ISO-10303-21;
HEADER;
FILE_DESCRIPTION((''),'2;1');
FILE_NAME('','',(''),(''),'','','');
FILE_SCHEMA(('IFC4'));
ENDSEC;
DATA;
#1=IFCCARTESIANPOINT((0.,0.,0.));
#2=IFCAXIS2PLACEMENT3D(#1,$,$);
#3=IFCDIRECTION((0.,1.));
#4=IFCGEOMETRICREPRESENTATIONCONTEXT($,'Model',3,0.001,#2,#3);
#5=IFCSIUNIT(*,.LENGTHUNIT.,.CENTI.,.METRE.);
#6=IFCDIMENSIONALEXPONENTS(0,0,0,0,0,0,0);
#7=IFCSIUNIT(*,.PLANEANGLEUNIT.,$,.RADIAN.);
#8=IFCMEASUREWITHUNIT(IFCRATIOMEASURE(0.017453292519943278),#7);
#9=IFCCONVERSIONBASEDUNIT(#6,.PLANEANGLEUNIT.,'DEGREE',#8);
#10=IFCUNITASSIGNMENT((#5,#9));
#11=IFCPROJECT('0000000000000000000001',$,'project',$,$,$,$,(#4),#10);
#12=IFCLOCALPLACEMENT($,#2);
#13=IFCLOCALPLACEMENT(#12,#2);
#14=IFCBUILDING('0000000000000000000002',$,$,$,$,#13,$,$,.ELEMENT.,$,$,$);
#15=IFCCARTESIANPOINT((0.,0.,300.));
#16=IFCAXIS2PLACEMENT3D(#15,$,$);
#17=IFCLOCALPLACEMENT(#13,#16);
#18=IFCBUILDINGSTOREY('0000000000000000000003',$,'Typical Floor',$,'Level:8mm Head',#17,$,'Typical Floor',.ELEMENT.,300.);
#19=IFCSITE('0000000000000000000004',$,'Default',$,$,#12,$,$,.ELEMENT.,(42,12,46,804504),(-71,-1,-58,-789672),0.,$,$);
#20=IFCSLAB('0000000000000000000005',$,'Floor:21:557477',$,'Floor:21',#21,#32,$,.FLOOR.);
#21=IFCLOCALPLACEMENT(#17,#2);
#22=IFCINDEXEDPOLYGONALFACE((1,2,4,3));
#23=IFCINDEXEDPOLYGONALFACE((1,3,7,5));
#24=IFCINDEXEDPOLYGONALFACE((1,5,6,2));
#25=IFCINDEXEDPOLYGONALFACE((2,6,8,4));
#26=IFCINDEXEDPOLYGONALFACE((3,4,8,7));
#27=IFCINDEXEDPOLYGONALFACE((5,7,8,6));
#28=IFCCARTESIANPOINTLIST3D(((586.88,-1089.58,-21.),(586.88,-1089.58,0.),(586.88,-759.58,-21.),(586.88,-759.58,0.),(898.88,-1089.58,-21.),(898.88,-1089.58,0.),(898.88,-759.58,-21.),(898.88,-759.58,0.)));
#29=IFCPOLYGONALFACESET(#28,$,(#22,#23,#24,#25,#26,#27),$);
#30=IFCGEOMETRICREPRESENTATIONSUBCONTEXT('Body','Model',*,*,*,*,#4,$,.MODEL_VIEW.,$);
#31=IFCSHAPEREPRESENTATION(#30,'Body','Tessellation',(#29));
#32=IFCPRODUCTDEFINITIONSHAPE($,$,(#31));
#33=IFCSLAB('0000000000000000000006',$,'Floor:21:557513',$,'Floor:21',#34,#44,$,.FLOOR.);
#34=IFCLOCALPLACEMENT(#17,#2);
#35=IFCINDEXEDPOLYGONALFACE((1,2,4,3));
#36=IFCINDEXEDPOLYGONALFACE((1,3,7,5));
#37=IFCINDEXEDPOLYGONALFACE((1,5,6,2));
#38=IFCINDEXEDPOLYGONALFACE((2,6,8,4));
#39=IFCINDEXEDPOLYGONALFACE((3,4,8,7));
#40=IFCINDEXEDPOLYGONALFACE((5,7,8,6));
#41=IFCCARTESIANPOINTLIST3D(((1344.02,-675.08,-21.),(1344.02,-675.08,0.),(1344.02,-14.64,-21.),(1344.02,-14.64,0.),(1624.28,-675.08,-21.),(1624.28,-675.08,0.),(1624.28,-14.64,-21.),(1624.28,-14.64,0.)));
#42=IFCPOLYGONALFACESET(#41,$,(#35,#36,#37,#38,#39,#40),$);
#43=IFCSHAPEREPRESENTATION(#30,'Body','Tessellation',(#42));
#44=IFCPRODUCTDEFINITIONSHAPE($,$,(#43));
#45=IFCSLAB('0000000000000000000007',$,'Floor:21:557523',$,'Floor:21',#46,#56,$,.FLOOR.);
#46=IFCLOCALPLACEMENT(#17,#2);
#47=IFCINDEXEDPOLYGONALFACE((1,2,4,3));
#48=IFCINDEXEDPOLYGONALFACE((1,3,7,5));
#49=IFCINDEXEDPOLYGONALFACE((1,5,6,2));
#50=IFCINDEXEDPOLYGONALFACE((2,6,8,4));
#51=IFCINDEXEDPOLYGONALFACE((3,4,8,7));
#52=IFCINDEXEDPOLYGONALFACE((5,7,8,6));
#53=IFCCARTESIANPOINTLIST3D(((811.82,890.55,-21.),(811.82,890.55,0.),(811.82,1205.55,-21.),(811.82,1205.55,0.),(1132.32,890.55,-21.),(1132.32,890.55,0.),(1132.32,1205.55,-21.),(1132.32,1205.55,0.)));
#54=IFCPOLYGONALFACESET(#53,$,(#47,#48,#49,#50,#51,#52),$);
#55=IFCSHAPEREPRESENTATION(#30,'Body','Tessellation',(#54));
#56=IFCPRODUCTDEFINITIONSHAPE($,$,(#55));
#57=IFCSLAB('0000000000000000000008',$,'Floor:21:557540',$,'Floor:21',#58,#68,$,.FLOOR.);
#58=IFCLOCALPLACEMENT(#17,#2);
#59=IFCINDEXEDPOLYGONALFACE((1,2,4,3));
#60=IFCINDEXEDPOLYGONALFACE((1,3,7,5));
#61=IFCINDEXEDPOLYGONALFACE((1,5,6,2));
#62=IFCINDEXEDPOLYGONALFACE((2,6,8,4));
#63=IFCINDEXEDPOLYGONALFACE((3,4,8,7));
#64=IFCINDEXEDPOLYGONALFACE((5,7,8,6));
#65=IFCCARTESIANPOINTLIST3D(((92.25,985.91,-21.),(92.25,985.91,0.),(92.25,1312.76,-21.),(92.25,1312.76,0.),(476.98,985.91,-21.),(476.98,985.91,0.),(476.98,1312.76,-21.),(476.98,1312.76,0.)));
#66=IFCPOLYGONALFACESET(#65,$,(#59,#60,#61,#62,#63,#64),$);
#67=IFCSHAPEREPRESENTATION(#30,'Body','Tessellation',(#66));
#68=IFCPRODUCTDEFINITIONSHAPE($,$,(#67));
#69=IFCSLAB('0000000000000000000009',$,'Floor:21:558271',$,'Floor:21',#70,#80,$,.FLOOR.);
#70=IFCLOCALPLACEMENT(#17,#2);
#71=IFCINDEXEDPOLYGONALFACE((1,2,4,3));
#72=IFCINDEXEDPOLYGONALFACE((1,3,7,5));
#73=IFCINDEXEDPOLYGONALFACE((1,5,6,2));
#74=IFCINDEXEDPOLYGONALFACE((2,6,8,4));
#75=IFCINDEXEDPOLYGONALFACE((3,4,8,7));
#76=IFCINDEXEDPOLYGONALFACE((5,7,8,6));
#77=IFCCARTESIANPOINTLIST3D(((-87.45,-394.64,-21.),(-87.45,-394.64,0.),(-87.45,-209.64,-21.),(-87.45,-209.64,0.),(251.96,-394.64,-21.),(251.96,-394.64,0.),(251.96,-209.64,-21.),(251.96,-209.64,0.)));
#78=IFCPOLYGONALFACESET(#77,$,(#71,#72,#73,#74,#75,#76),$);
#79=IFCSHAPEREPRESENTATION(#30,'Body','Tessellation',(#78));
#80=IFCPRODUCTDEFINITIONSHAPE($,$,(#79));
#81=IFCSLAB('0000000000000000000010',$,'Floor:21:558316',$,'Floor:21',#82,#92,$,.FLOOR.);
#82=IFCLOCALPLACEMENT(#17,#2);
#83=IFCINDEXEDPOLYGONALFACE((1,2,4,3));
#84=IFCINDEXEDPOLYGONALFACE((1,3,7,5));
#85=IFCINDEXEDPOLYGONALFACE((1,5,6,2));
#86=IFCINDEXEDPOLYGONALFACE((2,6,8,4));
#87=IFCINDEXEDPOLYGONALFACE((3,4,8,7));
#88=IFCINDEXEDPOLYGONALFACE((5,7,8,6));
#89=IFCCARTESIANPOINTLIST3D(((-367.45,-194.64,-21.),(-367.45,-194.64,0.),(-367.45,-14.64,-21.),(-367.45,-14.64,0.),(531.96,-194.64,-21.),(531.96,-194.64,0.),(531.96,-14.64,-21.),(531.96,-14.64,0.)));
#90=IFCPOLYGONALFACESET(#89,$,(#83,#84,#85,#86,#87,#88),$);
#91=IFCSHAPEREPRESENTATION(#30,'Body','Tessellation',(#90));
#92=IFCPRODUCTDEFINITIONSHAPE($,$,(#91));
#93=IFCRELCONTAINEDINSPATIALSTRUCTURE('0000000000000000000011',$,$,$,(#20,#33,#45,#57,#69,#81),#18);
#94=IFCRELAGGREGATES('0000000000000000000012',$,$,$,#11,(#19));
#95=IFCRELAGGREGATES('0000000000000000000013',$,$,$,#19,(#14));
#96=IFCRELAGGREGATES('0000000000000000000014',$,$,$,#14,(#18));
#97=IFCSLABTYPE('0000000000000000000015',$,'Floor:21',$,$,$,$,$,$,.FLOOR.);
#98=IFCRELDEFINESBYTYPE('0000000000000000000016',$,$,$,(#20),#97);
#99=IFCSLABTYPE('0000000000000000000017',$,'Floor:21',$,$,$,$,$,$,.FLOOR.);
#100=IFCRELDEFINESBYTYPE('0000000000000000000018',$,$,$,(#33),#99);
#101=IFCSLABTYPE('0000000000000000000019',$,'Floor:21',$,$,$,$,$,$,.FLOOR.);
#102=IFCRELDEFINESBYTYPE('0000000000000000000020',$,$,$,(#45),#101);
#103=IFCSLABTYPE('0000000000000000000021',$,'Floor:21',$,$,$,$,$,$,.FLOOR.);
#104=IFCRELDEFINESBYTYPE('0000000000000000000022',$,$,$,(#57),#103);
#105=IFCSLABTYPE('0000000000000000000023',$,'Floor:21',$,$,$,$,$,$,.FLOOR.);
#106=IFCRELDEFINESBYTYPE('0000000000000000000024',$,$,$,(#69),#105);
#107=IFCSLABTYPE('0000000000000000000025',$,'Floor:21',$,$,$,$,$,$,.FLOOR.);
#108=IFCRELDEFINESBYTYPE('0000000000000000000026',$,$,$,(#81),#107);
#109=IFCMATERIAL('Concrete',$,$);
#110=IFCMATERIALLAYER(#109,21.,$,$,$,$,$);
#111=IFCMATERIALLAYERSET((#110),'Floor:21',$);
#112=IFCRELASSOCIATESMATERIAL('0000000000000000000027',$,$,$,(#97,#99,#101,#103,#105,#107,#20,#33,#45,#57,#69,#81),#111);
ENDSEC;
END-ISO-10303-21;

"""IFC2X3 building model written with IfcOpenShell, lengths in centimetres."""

from ifc_helpers import new_model, entity, si_unit, converted_unit, direction, frame, frame_2d, origin, origin_2d_with_axis, place, context, subcontext, project, spatial, rectangle, extrude, material, layer, layer_set, layer_usage, type_object, element, save


model = new_model("IFC2X3")

# Units and contexts
model_context = context("Model", 3, precision=0.001, world=origin(), true_north=direction((0.0, 1.0)))
body_context = subcontext(model_context, "Body", "Model", "MODEL_VIEW")
ifc_project = project(units=[si_unit("LENGTHUNIT", "METRE", prefix="CENTI"), converted_unit("PLANEANGLEUNIT", "DEGREE", entity("IfcRatioMeasure", 0.017453292519943278), si_unit("PLANEANGLEUNIT", "RADIAN"), dimensions=[0, 0, 0, 0, 0, 0, 0])], contexts=[model_context])

# Site, building, storey
site_placement = place(None, origin())
site = spatial("IfcSite", under=ifc_project, at=site_placement, Name="Default", CompositionType="ELEMENT", RefLatitude=(42, 12, 46, 804504), RefLongitude=(-71, -1, -58, -789672), RefElevation=0.0)
building_placement = place(site_placement, origin())
building = spatial("IfcBuilding", under=site, at=building_placement, CompositionType="ELEMENT")
storey_placement = place(building_placement, frame((0.0, 0.0, 300.0)))
storey = spatial("IfcBuildingStorey", under=building, at=storey_placement, Name="Typical Floor", ObjectType="Level:8mm Head", LongName="Typical Floor", CompositionType="ELEMENT", Elevation=300.0)

# Shared definitions
ifc_material = material(Name="Concrete")

# Slabs
ifc_layer = layer(ifc_material, 21.0)
ifc_layer_set = layer_set([ifc_layer], Name="Floor:21")
ifc_layer_usage_1 = layer_usage(ifc_layer_set, "AXIS3", "POSITIVE", 0.0)
slab_type_1 = type_object("IfcSlabType", Name="Floor:21", PredefinedType="FLOOR", material=ifc_layer_set)
slab_1_placement = place(storey_placement, origin())
element("IfcSlab", 1, at=slab_1_placement, inside=storey, type_object=slab_type_1, material=ifc_layer_usage_1, Name="Floor:21:557477", ObjectType="Floor:21", PredefinedType="FLOOR", context=body_context, shape_type="SweptSolid", body=[
    extrude(rectangle(XDim=330.0, YDim=312.0, at=frame_2d((0.0, 0.0), x_axis=(1.0, 0.0))), frame((742.88, -924.58, 0.0), z_axis=(0.0, 0.0, -1.0), x_axis=(0.0, 1.0, 0.0)), (0.0, 0.0, 1.0), 21.0),
])
ifc_layer_usage_2 = layer_usage(ifc_layer_set, "AXIS3", "POSITIVE", 0.0)
slab_type_2 = type_object("IfcSlabType", Name="Floor:21", PredefinedType="FLOOR", material=ifc_layer_set)
slab_2_placement = place(storey_placement, origin())
element("IfcSlab", 2, at=slab_2_placement, inside=storey, type_object=slab_type_2, material=ifc_layer_usage_2, Name="Floor:21:557513", ObjectType="Floor:21", PredefinedType="FLOOR", context=body_context, shape_type="SweptSolid", body=[
    extrude(rectangle(XDim=660.45, YDim=280.26, at=frame_2d((0.0, 0.0), x_axis=(1.0, 0.0))), frame((1484.15, -344.86, 0.0), z_axis=(0.0, 0.0, -1.0), x_axis=(0.0, 1.0, 0.0)), (0.0, 0.0, 1.0), 21.0),
])
ifc_layer_usage_3 = layer_usage(ifc_layer_set, "AXIS3", "POSITIVE", 0.0)
slab_type_3 = type_object("IfcSlabType", Name="Floor:21", PredefinedType="FLOOR", material=ifc_layer_set)
slab_3_placement = place(storey_placement, origin())
element("IfcSlab", 3, at=slab_3_placement, inside=storey, type_object=slab_type_3, material=ifc_layer_usage_3, Name="Floor:21:557523", ObjectType="Floor:21", PredefinedType="FLOOR", context=body_context, shape_type="SweptSolid", body=[
    extrude(rectangle(XDim=315.0, YDim=320.5, at=frame_2d((0.0, 0.0), x_axis=(1.0, 0.0))), frame((972.07, 1048.05, 0.0), z_axis=(0.0, 0.0, -1.0), x_axis=(0.0, 1.0, 0.0)), (0.0, 0.0, 1.0), 21.0),
])
ifc_layer_usage_4 = layer_usage(ifc_layer_set, "AXIS3", "POSITIVE", 0.0)
slab_type_4 = type_object("IfcSlabType", Name="Floor:21", PredefinedType="FLOOR", material=ifc_layer_set)
slab_4_placement = place(storey_placement, origin())
element("IfcSlab", 4, at=slab_4_placement, inside=storey, type_object=slab_type_4, material=ifc_layer_usage_4, Name="Floor:21:557540", ObjectType="Floor:21", PredefinedType="FLOOR", context=body_context, shape_type="SweptSolid", body=[
    extrude(rectangle(XDim=326.85, YDim=384.73, at=origin_2d_with_axis()), frame((284.62, 1149.33, 0.0), z_axis=(0.0, 0.0, -1.0), x_axis=(0.0, 1.0, 0.0)), (0.0, 0.0, 1.0), 21.0),
])
ifc_layer_usage_5 = layer_usage(ifc_layer_set, "AXIS3", "POSITIVE", 0.0)
slab_type_5 = type_object("IfcSlabType", Name="Floor:21", PredefinedType="FLOOR", material=ifc_layer_set)
slab_5_placement = place(storey_placement, origin())
element("IfcSlab", 5, at=slab_5_placement, inside=storey, type_object=slab_type_5, material=ifc_layer_usage_5, Name="Floor:21:558271", ObjectType="Floor:21", PredefinedType="FLOOR", context=body_context, shape_type="SweptSolid", body=[
    extrude(rectangle(XDim=185.0, YDim=339.41, at=frame_2d((0.0, 0.0), x_axis=(1.0, 0.0))), frame((82.25, -302.14, 0.0), z_axis=(0.0, 0.0, -1.0), x_axis=(0.0, 1.0, 0.0)), (0.0, 0.0, 1.0), 21.0),
])
ifc_layer_usage_6 = layer_usage(ifc_layer_set, "AXIS3", "POSITIVE", 0.0)
slab_type_6 = type_object("IfcSlabType", Name="Floor:21", PredefinedType="FLOOR", material=ifc_layer_set)
slab_6_placement = place(storey_placement, origin())
element("IfcSlab", 6, at=slab_6_placement, inside=storey, type_object=slab_type_6, material=ifc_layer_usage_6, Name="Floor:21:558316", ObjectType="Floor:21", PredefinedType="FLOOR", context=body_context, shape_type="SweptSolid", body=[
    extrude(rectangle(XDim=180.0, YDim=899.41, at=origin_2d_with_axis()), frame((82.25, -104.64, 0.0), z_axis=(0.0, 0.0, -1.0), x_axis=(0.0, 1.0, 0.0)), (0.0, 0.0, 1.0), 21.0),
])

save(model, "model.ifc")
